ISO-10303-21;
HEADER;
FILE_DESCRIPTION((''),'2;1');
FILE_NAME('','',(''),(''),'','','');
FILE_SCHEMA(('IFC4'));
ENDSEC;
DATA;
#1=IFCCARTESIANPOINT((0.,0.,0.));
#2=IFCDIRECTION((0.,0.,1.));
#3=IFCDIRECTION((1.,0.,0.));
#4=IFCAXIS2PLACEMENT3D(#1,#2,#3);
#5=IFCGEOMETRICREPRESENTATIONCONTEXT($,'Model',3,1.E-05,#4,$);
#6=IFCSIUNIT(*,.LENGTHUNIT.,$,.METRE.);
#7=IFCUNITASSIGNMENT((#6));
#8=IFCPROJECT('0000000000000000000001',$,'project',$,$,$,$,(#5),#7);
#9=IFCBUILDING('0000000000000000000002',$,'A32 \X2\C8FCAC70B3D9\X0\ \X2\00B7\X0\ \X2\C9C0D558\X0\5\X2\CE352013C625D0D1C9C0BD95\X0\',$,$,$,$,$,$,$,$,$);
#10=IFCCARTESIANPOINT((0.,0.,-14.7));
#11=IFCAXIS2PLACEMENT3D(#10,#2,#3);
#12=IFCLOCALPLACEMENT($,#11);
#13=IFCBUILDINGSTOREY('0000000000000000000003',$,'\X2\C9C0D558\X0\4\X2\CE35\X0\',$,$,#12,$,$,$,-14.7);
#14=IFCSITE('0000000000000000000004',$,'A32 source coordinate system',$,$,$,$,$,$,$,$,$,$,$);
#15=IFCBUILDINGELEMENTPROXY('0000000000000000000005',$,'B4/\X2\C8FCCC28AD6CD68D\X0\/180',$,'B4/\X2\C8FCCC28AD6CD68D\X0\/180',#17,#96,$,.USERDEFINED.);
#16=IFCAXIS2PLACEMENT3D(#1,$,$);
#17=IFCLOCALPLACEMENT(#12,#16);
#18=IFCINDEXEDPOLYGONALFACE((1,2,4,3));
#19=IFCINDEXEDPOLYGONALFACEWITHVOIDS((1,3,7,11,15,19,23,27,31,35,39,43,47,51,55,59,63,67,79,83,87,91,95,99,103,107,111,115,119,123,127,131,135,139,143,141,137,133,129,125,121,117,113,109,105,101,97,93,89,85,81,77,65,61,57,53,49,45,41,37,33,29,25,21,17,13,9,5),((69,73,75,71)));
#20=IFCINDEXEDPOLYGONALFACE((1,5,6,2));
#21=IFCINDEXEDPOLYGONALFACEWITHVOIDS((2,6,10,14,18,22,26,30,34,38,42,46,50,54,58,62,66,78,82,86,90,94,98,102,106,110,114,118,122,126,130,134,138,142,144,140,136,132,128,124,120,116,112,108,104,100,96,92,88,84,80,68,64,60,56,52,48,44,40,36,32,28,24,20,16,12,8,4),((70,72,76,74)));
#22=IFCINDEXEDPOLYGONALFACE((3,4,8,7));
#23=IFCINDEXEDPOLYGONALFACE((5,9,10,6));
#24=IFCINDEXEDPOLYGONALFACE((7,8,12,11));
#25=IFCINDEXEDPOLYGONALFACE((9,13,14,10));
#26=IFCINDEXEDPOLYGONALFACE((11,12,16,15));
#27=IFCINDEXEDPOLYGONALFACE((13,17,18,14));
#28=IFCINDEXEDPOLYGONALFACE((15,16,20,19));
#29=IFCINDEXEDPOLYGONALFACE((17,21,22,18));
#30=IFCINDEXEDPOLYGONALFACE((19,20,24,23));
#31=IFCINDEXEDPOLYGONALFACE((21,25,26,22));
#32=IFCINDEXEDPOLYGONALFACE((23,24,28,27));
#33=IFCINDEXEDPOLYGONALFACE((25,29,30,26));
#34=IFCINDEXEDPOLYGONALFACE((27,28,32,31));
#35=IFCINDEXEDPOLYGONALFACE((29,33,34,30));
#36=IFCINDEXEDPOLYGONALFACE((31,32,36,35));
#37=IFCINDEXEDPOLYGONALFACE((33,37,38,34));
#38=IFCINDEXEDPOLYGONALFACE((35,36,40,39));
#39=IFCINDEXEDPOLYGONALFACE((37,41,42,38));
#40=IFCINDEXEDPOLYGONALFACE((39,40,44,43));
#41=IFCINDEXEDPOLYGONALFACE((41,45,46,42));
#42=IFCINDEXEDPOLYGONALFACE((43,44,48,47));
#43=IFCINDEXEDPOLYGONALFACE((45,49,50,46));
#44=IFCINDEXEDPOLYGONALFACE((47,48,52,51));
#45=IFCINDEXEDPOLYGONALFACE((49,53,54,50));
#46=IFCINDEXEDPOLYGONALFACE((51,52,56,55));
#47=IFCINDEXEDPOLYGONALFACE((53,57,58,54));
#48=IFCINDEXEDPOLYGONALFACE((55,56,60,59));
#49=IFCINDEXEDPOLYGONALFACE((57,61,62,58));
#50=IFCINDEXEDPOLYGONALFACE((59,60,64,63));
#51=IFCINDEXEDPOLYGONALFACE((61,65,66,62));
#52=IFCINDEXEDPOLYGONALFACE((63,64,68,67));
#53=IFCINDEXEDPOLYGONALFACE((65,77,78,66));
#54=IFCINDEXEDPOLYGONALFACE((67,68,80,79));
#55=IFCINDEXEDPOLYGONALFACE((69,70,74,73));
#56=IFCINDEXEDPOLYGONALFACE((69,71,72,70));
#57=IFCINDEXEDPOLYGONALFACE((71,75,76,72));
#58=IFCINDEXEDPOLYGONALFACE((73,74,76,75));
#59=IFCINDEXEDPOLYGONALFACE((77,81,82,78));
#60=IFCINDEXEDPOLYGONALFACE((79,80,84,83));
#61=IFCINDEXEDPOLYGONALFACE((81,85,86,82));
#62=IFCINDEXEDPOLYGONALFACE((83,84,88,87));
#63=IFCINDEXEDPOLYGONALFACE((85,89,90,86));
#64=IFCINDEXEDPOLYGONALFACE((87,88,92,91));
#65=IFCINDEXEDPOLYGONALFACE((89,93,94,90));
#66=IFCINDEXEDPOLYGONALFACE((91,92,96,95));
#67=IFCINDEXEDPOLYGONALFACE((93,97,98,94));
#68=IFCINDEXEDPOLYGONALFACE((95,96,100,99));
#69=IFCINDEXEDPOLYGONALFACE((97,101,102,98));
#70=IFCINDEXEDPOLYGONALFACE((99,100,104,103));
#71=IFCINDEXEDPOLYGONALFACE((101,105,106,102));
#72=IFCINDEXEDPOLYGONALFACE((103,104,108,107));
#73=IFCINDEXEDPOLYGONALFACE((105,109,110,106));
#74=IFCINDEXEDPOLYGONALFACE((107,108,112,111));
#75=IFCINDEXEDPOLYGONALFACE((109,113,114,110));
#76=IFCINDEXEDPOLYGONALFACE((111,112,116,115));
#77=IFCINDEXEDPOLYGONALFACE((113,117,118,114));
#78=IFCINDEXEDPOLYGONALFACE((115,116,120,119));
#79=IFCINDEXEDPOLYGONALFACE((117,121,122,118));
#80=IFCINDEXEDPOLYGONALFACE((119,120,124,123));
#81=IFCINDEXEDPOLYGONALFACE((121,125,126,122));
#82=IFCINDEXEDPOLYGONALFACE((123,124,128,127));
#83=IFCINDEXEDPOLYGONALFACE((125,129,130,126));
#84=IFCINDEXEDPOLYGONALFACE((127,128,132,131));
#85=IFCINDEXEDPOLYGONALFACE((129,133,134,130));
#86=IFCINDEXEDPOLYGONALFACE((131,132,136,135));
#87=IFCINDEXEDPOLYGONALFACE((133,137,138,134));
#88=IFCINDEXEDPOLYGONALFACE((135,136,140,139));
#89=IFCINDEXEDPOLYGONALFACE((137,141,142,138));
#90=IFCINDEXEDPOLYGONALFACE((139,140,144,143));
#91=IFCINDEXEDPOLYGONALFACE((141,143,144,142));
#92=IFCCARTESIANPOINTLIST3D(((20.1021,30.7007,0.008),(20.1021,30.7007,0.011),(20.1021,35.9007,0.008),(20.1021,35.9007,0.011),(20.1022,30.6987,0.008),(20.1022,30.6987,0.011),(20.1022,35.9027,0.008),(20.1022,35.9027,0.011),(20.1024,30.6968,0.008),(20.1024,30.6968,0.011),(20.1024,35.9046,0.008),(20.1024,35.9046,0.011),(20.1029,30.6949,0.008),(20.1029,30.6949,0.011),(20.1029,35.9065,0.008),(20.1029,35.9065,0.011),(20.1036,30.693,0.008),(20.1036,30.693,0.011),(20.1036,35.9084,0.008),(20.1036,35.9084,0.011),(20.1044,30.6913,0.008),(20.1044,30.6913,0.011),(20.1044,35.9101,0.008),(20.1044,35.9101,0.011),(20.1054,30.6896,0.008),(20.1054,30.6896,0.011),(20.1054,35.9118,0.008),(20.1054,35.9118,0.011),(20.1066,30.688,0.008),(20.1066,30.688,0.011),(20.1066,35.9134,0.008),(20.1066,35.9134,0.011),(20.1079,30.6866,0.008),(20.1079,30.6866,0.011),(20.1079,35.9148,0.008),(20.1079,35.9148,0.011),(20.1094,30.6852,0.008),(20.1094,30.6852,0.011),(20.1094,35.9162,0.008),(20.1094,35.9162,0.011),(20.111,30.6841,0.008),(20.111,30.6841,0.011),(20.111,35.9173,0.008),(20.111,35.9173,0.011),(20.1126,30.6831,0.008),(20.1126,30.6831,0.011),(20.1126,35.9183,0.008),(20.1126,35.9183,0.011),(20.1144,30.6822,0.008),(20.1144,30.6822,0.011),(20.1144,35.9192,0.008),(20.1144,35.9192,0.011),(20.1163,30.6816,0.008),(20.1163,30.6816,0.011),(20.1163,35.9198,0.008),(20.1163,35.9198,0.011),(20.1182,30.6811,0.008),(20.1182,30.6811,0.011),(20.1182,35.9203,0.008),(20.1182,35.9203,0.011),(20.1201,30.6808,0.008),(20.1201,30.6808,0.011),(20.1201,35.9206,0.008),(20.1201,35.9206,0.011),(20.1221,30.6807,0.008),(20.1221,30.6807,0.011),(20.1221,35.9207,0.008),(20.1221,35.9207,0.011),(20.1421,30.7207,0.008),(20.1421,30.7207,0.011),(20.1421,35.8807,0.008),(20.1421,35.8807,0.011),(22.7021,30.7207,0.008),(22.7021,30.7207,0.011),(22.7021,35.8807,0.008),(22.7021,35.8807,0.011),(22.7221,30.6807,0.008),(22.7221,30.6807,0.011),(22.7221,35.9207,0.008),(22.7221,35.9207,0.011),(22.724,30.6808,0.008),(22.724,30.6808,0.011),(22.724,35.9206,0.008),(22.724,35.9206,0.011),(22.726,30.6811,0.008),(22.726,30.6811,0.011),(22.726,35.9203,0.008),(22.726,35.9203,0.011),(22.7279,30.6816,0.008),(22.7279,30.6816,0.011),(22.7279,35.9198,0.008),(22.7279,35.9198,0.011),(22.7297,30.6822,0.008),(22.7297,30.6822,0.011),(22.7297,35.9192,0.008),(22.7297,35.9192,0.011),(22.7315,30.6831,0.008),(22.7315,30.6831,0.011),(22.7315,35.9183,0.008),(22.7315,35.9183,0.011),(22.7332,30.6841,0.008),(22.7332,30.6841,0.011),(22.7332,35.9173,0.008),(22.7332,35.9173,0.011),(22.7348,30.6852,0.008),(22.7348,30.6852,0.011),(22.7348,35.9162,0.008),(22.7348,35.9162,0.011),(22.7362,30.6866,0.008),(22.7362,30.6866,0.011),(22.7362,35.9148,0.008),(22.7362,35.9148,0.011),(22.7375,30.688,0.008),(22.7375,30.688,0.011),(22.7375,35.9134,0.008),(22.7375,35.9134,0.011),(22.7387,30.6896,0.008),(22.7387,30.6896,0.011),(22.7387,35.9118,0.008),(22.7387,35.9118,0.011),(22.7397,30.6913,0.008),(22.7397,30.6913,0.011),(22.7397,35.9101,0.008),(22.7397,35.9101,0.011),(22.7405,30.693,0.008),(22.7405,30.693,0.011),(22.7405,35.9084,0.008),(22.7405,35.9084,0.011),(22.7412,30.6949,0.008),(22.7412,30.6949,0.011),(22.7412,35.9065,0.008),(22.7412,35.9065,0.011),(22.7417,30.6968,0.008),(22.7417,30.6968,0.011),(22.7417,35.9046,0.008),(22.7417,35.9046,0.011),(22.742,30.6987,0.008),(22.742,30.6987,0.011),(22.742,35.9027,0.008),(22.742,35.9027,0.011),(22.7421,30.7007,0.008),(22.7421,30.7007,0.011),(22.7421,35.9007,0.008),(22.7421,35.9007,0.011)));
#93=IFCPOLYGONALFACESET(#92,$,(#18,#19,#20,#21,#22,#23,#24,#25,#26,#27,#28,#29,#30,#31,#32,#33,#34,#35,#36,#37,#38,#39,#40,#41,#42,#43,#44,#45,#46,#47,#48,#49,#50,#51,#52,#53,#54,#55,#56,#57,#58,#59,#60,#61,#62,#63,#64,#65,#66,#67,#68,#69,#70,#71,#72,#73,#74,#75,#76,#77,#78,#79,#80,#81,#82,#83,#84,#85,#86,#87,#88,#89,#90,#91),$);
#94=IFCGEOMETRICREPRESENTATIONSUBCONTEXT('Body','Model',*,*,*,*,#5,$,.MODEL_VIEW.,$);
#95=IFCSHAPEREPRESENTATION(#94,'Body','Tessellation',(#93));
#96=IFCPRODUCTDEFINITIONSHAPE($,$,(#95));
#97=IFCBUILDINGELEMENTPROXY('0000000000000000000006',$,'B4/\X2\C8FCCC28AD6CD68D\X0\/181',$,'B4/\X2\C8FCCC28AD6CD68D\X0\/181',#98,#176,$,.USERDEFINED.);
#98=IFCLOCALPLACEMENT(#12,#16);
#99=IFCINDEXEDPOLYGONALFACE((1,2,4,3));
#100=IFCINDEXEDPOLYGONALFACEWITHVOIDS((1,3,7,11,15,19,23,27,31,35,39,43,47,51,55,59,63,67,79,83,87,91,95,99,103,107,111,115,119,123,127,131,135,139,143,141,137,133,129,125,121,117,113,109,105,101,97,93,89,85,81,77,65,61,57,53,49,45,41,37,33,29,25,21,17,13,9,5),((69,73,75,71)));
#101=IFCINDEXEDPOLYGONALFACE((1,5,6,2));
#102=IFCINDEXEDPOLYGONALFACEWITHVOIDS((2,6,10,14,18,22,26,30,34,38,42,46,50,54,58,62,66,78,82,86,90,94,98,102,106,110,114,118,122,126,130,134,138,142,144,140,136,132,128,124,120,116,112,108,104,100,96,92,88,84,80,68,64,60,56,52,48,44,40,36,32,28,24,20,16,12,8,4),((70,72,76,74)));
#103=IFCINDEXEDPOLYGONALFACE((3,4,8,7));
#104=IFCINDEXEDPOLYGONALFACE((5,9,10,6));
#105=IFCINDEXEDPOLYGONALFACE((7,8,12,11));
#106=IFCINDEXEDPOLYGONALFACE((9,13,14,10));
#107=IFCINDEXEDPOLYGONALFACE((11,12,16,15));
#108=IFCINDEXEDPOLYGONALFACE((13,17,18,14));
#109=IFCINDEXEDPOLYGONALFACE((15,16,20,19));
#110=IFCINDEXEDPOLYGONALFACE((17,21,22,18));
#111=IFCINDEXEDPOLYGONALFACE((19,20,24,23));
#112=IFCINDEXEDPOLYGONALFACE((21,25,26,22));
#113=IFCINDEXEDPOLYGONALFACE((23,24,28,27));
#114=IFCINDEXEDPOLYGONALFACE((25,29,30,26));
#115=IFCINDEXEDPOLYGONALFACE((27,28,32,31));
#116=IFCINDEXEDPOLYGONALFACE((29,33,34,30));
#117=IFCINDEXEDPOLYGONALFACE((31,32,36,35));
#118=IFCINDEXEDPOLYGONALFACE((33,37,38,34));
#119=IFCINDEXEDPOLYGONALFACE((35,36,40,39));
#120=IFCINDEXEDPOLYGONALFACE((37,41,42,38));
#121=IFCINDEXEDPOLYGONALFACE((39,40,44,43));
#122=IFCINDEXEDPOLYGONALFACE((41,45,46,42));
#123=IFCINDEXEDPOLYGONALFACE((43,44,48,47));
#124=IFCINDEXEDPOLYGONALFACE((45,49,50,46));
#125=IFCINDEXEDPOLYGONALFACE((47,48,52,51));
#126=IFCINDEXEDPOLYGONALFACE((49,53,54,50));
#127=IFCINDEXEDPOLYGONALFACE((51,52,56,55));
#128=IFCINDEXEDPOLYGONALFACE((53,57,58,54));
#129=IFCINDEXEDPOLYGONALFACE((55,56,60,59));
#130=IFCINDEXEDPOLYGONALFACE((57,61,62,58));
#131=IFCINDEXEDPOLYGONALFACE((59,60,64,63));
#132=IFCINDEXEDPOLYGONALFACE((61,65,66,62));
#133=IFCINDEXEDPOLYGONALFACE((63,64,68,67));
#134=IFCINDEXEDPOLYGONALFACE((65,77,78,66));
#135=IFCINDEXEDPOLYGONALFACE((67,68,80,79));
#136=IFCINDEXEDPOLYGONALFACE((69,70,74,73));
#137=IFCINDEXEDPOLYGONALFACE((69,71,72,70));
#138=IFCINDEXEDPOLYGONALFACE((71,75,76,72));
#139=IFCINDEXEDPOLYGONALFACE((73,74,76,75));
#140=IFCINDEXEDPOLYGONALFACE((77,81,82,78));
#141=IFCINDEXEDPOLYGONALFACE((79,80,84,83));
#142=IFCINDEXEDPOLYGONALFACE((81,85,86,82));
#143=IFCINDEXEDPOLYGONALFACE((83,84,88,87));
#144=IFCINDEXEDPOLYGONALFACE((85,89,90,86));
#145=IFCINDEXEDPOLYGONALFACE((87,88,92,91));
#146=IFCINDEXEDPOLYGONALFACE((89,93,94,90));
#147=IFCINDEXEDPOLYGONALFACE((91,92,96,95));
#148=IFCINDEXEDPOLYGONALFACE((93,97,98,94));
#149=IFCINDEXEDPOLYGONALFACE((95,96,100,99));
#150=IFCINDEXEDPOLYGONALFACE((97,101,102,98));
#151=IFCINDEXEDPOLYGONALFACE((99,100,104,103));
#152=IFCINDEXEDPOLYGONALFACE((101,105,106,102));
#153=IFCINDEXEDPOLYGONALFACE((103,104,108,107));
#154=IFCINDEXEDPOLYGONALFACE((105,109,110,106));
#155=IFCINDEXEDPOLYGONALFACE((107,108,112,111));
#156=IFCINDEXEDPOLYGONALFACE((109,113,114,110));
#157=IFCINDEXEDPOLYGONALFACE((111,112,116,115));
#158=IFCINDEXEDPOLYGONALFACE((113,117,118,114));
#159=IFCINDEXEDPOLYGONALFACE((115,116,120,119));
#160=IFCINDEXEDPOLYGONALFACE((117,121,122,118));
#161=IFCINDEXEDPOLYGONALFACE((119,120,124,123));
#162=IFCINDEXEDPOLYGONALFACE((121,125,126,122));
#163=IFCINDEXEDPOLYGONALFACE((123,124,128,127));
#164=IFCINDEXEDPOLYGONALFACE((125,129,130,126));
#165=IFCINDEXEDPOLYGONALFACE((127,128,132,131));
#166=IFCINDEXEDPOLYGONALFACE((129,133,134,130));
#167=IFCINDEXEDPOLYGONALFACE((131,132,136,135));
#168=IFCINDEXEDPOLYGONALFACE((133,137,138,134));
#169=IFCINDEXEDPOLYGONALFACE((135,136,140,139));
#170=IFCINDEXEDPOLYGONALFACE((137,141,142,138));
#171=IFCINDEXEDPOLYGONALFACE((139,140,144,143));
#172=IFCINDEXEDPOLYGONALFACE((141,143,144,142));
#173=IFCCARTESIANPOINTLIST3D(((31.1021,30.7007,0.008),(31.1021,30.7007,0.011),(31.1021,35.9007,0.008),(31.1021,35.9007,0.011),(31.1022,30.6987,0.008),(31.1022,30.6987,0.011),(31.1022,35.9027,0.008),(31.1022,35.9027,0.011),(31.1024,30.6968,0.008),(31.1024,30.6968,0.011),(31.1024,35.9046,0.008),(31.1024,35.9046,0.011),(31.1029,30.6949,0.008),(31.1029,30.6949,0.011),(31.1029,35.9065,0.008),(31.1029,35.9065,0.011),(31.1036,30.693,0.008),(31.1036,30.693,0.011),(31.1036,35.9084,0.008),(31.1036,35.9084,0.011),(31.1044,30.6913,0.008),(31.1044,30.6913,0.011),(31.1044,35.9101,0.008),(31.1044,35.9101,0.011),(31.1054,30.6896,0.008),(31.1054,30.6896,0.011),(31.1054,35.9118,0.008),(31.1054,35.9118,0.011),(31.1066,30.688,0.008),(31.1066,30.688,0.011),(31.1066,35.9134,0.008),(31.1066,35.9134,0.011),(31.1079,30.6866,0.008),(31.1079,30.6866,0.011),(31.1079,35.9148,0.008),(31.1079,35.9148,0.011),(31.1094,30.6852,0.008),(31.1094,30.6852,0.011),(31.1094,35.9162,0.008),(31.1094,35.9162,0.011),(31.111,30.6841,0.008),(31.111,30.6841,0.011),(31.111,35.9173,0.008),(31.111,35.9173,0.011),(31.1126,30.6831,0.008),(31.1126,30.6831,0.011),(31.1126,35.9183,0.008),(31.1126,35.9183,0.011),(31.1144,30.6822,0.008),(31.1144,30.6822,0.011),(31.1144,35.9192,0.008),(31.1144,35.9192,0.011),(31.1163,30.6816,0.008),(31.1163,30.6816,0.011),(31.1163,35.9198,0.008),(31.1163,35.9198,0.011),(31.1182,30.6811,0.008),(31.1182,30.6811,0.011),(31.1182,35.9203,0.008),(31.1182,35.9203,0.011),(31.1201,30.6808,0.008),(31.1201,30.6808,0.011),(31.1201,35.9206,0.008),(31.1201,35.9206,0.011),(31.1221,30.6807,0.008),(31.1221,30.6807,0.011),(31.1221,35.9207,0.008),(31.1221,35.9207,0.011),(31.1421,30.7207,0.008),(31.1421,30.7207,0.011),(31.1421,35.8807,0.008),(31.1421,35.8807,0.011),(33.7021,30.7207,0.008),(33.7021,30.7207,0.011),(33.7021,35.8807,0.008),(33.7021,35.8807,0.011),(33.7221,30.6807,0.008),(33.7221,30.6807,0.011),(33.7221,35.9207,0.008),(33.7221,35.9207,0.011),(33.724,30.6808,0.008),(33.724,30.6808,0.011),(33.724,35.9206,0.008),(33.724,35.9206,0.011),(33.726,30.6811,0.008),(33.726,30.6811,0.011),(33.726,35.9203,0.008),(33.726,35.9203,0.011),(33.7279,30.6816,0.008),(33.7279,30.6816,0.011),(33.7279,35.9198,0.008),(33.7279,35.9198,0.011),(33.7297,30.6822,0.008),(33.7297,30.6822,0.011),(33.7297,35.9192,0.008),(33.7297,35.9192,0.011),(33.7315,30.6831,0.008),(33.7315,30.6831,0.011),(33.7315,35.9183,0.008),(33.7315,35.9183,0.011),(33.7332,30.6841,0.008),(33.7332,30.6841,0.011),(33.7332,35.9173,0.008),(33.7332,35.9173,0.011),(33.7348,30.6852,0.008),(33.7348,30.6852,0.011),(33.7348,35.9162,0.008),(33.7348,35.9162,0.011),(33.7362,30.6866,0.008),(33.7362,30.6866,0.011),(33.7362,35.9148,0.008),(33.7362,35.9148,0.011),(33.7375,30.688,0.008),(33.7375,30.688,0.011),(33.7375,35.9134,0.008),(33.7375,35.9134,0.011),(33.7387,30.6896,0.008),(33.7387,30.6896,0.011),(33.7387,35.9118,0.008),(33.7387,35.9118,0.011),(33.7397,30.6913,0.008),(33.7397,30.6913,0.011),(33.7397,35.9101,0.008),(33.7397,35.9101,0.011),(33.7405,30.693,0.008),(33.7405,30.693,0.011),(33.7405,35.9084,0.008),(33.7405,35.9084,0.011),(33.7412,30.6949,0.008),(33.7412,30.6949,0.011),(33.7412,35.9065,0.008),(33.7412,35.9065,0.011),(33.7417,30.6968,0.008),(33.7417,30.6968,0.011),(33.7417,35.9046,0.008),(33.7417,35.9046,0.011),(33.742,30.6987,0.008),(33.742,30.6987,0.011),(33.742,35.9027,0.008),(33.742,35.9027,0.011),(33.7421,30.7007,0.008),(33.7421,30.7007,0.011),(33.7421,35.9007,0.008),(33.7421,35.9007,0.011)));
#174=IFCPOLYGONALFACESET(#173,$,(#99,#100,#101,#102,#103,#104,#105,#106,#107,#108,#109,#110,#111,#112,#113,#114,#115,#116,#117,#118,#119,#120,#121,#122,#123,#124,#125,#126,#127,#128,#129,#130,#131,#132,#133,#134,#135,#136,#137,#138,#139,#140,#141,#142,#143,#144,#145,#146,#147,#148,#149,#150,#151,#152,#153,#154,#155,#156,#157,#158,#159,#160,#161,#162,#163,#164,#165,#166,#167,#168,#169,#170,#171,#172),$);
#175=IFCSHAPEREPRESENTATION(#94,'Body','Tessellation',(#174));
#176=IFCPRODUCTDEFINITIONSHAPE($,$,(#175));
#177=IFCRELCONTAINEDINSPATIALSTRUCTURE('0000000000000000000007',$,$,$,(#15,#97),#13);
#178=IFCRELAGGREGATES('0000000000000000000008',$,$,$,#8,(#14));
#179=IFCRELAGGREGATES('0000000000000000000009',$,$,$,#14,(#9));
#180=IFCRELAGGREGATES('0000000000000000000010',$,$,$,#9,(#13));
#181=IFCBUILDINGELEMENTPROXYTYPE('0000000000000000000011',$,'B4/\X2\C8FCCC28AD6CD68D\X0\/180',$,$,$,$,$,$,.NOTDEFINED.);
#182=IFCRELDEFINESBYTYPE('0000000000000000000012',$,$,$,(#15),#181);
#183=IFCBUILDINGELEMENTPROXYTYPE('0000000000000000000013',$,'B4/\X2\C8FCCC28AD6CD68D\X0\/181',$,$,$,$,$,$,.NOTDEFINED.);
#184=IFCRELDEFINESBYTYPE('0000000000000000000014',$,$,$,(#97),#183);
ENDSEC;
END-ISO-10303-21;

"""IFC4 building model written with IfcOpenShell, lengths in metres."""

from ifc_helpers import new_model, si_unit, frame, origin, origin_with_axes, place, context, subcontext, project, spatial, polyline, outline, extrude, source, transform, mapped, type_object, type_shapes, element, save


model = new_model("IFC4")

# Units and contexts
model_context = context("Model", 3, precision=1e-05, world=origin_with_axes())
body_context = subcontext(model_context, "Body", "Model", "MODEL_VIEW")
ifc_project = project(units=[si_unit("LENGTHUNIT", "METRE")], contexts=[model_context])

# Site, building, storey
site = spatial("IfcSite", under=ifc_project, Name="A32 source coordinate system")
building = spatial("IfcBuilding", under=site, Name="A32 주거동 · 지하5층–옥탑지붕")
storey_placement = place(None, frame((0.0, 0.0, -14.7), z_axis=(0.0, 0.0, 1.0), x_axis=(1.0, 0.0, 0.0)))
storey = spatial("IfcBuildingStorey", under=building, at=storey_placement, Name="지하4층", Elevation=-14.7)

# Building element proxies
building_element_proxy_type_1 = type_object("IfcBuildingElementProxyType", Name="B4/주차구획/180", PredefinedType="NOTDEFINED")
shared_shape_1 = source(origin(), body_context, "Body", "SweptSolid", [
    extrude(outline(polyline([(20.1021, 35.9007), (20.1022, 35.9027), (20.1024, 35.9046), (20.1029, 35.9065), (20.1036, 35.9084), (20.1044, 35.9101), (20.1054, 35.9118), (20.1066, 35.9134), (20.1079, 35.9148), (20.1094, 35.9162), (20.111, 35.9173), (20.1126, 35.9183), (20.1144, 35.9192), (20.1163, 35.9198), (20.1182, 35.9203), (20.1201, 35.9206), (20.1221, 35.9207), (22.7221, 35.9207), (22.724, 35.9206), (22.726, 35.9203), (22.7279, 35.9198), (22.7297, 35.9192), (22.7315, 35.9183), (22.7332, 35.9173), (22.7348, 35.9162), (22.7362, 35.9148), (22.7375, 35.9134), (22.7387, 35.9118), (22.7397, 35.9101), (22.7405, 35.9084), (22.7412, 35.9065), (22.7417, 35.9046), (22.742, 35.9027), (22.7421, 35.9007), (22.7421, 30.7007), (22.742, 30.6987), (22.7417, 30.6968), (22.7412, 30.6949), (22.7405, 30.693), (22.7397, 30.6913), (22.7387, 30.6896), (22.7375, 30.688), (22.7362, 30.6866), (22.7348, 30.6852), (22.7332, 30.6841), (22.7315, 30.6831), (22.7297, 30.6822), (22.7279, 30.6816), (22.726, 30.6811), (22.724, 30.6808), (22.7221, 30.6807), (20.1221, 30.6807), (20.1201, 30.6808), (20.1182, 30.6811), (20.1163, 30.6816), (20.1144, 30.6822), (20.1126, 30.6831), (20.111, 30.6841), (20.1094, 30.6852), (20.1079, 30.6866), (20.1066, 30.688), (20.1054, 30.6896), (20.1044, 30.6913), (20.1036, 30.693), (20.1029, 30.6949), (20.1024, 30.6968), (20.1022, 30.6987), (20.1021, 30.7007), (20.1021, 35.9007)]), holes=[polyline([(20.1421, 35.8807), (20.1421, 30.7207), (22.7021, 30.7207), (22.7021, 35.8807), (20.1421, 35.8807)])]), frame((0.0, 0.0, 0.008)), (0.0, 0.0, 1.0), 0.003),
])
type_shapes(building_element_proxy_type_1, [shared_shape_1])
proxy_1_placement = place(storey_placement, origin_with_axes())
element("IfcBuildingElementProxy", 1, at=proxy_1_placement, inside=storey, type_object=building_element_proxy_type_1, Name="B4/주차구획/180", ObjectType="B4/주차구획/180", PredefinedType="USERDEFINED", context=body_context, shape_type="MappedRepresentation", body=[
    mapped(shared_shape_1, transform((0.0, 0.0, 0.0), scale=1.0)),
])
building_element_proxy_type_2 = type_object("IfcBuildingElementProxyType", Name="B4/주차구획/181", PredefinedType="NOTDEFINED")
shared_shape_2 = source(origin(), body_context, "Body", "SweptSolid", [
    extrude(outline(polyline([(31.1021, 35.9007), (31.1022, 35.9027), (31.1024, 35.9046), (31.1029, 35.9065), (31.1036, 35.9084), (31.1044, 35.9101), (31.1054, 35.9118), (31.1066, 35.9134), (31.1079, 35.9148), (31.1094, 35.9162), (31.111, 35.9173), (31.1126, 35.9183), (31.1144, 35.9192), (31.1163, 35.9198), (31.1182, 35.9203), (31.1201, 35.9206), (31.1221, 35.9207), (33.7221, 35.9207), (33.724, 35.9206), (33.726, 35.9203), (33.7279, 35.9198), (33.7297, 35.9192), (33.7315, 35.9183), (33.7332, 35.9173), (33.7348, 35.9162), (33.7362, 35.9148), (33.7375, 35.9134), (33.7387, 35.9118), (33.7397, 35.9101), (33.7405, 35.9084), (33.7412, 35.9065), (33.7417, 35.9046), (33.742, 35.9027), (33.7421, 35.9007), (33.7421, 30.7007), (33.742, 30.6987), (33.7417, 30.6968), (33.7412, 30.6949), (33.7405, 30.693), (33.7397, 30.6913), (33.7387, 30.6896), (33.7375, 30.688), (33.7362, 30.6866), (33.7348, 30.6852), (33.7332, 30.6841), (33.7315, 30.6831), (33.7297, 30.6822), (33.7279, 30.6816), (33.726, 30.6811), (33.724, 30.6808), (33.7221, 30.6807), (31.1221, 30.6807), (31.1201, 30.6808), (31.1182, 30.6811), (31.1163, 30.6816), (31.1144, 30.6822), (31.1126, 30.6831), (31.111, 30.6841), (31.1094, 30.6852), (31.1079, 30.6866), (31.1066, 30.688), (31.1054, 30.6896), (31.1044, 30.6913), (31.1036, 30.693), (31.1029, 30.6949), (31.1024, 30.6968), (31.1022, 30.6987), (31.1021, 30.7007), (31.1021, 35.9007)]), holes=[polyline([(31.1421, 35.8807), (31.1421, 30.7207), (33.7021, 30.7207), (33.7021, 35.8807), (31.1421, 35.8807)])]), frame((0.0, 0.0, 0.008)), (0.0, 0.0, 1.0), 0.003),
])
type_shapes(building_element_proxy_type_2, [shared_shape_2])
proxy_2_placement = place(storey_placement, origin_with_axes())
element("IfcBuildingElementProxy", 2, at=proxy_2_placement, inside=storey, type_object=building_element_proxy_type_2, Name="B4/주차구획/181", ObjectType="B4/주차구획/181", PredefinedType="USERDEFINED", context=body_context, shape_type="MappedRepresentation", body=[
    mapped(shared_shape_2, transform((0.0, 0.0, 0.0), scale=1.0)),
])

save(model, "model.ifc")
